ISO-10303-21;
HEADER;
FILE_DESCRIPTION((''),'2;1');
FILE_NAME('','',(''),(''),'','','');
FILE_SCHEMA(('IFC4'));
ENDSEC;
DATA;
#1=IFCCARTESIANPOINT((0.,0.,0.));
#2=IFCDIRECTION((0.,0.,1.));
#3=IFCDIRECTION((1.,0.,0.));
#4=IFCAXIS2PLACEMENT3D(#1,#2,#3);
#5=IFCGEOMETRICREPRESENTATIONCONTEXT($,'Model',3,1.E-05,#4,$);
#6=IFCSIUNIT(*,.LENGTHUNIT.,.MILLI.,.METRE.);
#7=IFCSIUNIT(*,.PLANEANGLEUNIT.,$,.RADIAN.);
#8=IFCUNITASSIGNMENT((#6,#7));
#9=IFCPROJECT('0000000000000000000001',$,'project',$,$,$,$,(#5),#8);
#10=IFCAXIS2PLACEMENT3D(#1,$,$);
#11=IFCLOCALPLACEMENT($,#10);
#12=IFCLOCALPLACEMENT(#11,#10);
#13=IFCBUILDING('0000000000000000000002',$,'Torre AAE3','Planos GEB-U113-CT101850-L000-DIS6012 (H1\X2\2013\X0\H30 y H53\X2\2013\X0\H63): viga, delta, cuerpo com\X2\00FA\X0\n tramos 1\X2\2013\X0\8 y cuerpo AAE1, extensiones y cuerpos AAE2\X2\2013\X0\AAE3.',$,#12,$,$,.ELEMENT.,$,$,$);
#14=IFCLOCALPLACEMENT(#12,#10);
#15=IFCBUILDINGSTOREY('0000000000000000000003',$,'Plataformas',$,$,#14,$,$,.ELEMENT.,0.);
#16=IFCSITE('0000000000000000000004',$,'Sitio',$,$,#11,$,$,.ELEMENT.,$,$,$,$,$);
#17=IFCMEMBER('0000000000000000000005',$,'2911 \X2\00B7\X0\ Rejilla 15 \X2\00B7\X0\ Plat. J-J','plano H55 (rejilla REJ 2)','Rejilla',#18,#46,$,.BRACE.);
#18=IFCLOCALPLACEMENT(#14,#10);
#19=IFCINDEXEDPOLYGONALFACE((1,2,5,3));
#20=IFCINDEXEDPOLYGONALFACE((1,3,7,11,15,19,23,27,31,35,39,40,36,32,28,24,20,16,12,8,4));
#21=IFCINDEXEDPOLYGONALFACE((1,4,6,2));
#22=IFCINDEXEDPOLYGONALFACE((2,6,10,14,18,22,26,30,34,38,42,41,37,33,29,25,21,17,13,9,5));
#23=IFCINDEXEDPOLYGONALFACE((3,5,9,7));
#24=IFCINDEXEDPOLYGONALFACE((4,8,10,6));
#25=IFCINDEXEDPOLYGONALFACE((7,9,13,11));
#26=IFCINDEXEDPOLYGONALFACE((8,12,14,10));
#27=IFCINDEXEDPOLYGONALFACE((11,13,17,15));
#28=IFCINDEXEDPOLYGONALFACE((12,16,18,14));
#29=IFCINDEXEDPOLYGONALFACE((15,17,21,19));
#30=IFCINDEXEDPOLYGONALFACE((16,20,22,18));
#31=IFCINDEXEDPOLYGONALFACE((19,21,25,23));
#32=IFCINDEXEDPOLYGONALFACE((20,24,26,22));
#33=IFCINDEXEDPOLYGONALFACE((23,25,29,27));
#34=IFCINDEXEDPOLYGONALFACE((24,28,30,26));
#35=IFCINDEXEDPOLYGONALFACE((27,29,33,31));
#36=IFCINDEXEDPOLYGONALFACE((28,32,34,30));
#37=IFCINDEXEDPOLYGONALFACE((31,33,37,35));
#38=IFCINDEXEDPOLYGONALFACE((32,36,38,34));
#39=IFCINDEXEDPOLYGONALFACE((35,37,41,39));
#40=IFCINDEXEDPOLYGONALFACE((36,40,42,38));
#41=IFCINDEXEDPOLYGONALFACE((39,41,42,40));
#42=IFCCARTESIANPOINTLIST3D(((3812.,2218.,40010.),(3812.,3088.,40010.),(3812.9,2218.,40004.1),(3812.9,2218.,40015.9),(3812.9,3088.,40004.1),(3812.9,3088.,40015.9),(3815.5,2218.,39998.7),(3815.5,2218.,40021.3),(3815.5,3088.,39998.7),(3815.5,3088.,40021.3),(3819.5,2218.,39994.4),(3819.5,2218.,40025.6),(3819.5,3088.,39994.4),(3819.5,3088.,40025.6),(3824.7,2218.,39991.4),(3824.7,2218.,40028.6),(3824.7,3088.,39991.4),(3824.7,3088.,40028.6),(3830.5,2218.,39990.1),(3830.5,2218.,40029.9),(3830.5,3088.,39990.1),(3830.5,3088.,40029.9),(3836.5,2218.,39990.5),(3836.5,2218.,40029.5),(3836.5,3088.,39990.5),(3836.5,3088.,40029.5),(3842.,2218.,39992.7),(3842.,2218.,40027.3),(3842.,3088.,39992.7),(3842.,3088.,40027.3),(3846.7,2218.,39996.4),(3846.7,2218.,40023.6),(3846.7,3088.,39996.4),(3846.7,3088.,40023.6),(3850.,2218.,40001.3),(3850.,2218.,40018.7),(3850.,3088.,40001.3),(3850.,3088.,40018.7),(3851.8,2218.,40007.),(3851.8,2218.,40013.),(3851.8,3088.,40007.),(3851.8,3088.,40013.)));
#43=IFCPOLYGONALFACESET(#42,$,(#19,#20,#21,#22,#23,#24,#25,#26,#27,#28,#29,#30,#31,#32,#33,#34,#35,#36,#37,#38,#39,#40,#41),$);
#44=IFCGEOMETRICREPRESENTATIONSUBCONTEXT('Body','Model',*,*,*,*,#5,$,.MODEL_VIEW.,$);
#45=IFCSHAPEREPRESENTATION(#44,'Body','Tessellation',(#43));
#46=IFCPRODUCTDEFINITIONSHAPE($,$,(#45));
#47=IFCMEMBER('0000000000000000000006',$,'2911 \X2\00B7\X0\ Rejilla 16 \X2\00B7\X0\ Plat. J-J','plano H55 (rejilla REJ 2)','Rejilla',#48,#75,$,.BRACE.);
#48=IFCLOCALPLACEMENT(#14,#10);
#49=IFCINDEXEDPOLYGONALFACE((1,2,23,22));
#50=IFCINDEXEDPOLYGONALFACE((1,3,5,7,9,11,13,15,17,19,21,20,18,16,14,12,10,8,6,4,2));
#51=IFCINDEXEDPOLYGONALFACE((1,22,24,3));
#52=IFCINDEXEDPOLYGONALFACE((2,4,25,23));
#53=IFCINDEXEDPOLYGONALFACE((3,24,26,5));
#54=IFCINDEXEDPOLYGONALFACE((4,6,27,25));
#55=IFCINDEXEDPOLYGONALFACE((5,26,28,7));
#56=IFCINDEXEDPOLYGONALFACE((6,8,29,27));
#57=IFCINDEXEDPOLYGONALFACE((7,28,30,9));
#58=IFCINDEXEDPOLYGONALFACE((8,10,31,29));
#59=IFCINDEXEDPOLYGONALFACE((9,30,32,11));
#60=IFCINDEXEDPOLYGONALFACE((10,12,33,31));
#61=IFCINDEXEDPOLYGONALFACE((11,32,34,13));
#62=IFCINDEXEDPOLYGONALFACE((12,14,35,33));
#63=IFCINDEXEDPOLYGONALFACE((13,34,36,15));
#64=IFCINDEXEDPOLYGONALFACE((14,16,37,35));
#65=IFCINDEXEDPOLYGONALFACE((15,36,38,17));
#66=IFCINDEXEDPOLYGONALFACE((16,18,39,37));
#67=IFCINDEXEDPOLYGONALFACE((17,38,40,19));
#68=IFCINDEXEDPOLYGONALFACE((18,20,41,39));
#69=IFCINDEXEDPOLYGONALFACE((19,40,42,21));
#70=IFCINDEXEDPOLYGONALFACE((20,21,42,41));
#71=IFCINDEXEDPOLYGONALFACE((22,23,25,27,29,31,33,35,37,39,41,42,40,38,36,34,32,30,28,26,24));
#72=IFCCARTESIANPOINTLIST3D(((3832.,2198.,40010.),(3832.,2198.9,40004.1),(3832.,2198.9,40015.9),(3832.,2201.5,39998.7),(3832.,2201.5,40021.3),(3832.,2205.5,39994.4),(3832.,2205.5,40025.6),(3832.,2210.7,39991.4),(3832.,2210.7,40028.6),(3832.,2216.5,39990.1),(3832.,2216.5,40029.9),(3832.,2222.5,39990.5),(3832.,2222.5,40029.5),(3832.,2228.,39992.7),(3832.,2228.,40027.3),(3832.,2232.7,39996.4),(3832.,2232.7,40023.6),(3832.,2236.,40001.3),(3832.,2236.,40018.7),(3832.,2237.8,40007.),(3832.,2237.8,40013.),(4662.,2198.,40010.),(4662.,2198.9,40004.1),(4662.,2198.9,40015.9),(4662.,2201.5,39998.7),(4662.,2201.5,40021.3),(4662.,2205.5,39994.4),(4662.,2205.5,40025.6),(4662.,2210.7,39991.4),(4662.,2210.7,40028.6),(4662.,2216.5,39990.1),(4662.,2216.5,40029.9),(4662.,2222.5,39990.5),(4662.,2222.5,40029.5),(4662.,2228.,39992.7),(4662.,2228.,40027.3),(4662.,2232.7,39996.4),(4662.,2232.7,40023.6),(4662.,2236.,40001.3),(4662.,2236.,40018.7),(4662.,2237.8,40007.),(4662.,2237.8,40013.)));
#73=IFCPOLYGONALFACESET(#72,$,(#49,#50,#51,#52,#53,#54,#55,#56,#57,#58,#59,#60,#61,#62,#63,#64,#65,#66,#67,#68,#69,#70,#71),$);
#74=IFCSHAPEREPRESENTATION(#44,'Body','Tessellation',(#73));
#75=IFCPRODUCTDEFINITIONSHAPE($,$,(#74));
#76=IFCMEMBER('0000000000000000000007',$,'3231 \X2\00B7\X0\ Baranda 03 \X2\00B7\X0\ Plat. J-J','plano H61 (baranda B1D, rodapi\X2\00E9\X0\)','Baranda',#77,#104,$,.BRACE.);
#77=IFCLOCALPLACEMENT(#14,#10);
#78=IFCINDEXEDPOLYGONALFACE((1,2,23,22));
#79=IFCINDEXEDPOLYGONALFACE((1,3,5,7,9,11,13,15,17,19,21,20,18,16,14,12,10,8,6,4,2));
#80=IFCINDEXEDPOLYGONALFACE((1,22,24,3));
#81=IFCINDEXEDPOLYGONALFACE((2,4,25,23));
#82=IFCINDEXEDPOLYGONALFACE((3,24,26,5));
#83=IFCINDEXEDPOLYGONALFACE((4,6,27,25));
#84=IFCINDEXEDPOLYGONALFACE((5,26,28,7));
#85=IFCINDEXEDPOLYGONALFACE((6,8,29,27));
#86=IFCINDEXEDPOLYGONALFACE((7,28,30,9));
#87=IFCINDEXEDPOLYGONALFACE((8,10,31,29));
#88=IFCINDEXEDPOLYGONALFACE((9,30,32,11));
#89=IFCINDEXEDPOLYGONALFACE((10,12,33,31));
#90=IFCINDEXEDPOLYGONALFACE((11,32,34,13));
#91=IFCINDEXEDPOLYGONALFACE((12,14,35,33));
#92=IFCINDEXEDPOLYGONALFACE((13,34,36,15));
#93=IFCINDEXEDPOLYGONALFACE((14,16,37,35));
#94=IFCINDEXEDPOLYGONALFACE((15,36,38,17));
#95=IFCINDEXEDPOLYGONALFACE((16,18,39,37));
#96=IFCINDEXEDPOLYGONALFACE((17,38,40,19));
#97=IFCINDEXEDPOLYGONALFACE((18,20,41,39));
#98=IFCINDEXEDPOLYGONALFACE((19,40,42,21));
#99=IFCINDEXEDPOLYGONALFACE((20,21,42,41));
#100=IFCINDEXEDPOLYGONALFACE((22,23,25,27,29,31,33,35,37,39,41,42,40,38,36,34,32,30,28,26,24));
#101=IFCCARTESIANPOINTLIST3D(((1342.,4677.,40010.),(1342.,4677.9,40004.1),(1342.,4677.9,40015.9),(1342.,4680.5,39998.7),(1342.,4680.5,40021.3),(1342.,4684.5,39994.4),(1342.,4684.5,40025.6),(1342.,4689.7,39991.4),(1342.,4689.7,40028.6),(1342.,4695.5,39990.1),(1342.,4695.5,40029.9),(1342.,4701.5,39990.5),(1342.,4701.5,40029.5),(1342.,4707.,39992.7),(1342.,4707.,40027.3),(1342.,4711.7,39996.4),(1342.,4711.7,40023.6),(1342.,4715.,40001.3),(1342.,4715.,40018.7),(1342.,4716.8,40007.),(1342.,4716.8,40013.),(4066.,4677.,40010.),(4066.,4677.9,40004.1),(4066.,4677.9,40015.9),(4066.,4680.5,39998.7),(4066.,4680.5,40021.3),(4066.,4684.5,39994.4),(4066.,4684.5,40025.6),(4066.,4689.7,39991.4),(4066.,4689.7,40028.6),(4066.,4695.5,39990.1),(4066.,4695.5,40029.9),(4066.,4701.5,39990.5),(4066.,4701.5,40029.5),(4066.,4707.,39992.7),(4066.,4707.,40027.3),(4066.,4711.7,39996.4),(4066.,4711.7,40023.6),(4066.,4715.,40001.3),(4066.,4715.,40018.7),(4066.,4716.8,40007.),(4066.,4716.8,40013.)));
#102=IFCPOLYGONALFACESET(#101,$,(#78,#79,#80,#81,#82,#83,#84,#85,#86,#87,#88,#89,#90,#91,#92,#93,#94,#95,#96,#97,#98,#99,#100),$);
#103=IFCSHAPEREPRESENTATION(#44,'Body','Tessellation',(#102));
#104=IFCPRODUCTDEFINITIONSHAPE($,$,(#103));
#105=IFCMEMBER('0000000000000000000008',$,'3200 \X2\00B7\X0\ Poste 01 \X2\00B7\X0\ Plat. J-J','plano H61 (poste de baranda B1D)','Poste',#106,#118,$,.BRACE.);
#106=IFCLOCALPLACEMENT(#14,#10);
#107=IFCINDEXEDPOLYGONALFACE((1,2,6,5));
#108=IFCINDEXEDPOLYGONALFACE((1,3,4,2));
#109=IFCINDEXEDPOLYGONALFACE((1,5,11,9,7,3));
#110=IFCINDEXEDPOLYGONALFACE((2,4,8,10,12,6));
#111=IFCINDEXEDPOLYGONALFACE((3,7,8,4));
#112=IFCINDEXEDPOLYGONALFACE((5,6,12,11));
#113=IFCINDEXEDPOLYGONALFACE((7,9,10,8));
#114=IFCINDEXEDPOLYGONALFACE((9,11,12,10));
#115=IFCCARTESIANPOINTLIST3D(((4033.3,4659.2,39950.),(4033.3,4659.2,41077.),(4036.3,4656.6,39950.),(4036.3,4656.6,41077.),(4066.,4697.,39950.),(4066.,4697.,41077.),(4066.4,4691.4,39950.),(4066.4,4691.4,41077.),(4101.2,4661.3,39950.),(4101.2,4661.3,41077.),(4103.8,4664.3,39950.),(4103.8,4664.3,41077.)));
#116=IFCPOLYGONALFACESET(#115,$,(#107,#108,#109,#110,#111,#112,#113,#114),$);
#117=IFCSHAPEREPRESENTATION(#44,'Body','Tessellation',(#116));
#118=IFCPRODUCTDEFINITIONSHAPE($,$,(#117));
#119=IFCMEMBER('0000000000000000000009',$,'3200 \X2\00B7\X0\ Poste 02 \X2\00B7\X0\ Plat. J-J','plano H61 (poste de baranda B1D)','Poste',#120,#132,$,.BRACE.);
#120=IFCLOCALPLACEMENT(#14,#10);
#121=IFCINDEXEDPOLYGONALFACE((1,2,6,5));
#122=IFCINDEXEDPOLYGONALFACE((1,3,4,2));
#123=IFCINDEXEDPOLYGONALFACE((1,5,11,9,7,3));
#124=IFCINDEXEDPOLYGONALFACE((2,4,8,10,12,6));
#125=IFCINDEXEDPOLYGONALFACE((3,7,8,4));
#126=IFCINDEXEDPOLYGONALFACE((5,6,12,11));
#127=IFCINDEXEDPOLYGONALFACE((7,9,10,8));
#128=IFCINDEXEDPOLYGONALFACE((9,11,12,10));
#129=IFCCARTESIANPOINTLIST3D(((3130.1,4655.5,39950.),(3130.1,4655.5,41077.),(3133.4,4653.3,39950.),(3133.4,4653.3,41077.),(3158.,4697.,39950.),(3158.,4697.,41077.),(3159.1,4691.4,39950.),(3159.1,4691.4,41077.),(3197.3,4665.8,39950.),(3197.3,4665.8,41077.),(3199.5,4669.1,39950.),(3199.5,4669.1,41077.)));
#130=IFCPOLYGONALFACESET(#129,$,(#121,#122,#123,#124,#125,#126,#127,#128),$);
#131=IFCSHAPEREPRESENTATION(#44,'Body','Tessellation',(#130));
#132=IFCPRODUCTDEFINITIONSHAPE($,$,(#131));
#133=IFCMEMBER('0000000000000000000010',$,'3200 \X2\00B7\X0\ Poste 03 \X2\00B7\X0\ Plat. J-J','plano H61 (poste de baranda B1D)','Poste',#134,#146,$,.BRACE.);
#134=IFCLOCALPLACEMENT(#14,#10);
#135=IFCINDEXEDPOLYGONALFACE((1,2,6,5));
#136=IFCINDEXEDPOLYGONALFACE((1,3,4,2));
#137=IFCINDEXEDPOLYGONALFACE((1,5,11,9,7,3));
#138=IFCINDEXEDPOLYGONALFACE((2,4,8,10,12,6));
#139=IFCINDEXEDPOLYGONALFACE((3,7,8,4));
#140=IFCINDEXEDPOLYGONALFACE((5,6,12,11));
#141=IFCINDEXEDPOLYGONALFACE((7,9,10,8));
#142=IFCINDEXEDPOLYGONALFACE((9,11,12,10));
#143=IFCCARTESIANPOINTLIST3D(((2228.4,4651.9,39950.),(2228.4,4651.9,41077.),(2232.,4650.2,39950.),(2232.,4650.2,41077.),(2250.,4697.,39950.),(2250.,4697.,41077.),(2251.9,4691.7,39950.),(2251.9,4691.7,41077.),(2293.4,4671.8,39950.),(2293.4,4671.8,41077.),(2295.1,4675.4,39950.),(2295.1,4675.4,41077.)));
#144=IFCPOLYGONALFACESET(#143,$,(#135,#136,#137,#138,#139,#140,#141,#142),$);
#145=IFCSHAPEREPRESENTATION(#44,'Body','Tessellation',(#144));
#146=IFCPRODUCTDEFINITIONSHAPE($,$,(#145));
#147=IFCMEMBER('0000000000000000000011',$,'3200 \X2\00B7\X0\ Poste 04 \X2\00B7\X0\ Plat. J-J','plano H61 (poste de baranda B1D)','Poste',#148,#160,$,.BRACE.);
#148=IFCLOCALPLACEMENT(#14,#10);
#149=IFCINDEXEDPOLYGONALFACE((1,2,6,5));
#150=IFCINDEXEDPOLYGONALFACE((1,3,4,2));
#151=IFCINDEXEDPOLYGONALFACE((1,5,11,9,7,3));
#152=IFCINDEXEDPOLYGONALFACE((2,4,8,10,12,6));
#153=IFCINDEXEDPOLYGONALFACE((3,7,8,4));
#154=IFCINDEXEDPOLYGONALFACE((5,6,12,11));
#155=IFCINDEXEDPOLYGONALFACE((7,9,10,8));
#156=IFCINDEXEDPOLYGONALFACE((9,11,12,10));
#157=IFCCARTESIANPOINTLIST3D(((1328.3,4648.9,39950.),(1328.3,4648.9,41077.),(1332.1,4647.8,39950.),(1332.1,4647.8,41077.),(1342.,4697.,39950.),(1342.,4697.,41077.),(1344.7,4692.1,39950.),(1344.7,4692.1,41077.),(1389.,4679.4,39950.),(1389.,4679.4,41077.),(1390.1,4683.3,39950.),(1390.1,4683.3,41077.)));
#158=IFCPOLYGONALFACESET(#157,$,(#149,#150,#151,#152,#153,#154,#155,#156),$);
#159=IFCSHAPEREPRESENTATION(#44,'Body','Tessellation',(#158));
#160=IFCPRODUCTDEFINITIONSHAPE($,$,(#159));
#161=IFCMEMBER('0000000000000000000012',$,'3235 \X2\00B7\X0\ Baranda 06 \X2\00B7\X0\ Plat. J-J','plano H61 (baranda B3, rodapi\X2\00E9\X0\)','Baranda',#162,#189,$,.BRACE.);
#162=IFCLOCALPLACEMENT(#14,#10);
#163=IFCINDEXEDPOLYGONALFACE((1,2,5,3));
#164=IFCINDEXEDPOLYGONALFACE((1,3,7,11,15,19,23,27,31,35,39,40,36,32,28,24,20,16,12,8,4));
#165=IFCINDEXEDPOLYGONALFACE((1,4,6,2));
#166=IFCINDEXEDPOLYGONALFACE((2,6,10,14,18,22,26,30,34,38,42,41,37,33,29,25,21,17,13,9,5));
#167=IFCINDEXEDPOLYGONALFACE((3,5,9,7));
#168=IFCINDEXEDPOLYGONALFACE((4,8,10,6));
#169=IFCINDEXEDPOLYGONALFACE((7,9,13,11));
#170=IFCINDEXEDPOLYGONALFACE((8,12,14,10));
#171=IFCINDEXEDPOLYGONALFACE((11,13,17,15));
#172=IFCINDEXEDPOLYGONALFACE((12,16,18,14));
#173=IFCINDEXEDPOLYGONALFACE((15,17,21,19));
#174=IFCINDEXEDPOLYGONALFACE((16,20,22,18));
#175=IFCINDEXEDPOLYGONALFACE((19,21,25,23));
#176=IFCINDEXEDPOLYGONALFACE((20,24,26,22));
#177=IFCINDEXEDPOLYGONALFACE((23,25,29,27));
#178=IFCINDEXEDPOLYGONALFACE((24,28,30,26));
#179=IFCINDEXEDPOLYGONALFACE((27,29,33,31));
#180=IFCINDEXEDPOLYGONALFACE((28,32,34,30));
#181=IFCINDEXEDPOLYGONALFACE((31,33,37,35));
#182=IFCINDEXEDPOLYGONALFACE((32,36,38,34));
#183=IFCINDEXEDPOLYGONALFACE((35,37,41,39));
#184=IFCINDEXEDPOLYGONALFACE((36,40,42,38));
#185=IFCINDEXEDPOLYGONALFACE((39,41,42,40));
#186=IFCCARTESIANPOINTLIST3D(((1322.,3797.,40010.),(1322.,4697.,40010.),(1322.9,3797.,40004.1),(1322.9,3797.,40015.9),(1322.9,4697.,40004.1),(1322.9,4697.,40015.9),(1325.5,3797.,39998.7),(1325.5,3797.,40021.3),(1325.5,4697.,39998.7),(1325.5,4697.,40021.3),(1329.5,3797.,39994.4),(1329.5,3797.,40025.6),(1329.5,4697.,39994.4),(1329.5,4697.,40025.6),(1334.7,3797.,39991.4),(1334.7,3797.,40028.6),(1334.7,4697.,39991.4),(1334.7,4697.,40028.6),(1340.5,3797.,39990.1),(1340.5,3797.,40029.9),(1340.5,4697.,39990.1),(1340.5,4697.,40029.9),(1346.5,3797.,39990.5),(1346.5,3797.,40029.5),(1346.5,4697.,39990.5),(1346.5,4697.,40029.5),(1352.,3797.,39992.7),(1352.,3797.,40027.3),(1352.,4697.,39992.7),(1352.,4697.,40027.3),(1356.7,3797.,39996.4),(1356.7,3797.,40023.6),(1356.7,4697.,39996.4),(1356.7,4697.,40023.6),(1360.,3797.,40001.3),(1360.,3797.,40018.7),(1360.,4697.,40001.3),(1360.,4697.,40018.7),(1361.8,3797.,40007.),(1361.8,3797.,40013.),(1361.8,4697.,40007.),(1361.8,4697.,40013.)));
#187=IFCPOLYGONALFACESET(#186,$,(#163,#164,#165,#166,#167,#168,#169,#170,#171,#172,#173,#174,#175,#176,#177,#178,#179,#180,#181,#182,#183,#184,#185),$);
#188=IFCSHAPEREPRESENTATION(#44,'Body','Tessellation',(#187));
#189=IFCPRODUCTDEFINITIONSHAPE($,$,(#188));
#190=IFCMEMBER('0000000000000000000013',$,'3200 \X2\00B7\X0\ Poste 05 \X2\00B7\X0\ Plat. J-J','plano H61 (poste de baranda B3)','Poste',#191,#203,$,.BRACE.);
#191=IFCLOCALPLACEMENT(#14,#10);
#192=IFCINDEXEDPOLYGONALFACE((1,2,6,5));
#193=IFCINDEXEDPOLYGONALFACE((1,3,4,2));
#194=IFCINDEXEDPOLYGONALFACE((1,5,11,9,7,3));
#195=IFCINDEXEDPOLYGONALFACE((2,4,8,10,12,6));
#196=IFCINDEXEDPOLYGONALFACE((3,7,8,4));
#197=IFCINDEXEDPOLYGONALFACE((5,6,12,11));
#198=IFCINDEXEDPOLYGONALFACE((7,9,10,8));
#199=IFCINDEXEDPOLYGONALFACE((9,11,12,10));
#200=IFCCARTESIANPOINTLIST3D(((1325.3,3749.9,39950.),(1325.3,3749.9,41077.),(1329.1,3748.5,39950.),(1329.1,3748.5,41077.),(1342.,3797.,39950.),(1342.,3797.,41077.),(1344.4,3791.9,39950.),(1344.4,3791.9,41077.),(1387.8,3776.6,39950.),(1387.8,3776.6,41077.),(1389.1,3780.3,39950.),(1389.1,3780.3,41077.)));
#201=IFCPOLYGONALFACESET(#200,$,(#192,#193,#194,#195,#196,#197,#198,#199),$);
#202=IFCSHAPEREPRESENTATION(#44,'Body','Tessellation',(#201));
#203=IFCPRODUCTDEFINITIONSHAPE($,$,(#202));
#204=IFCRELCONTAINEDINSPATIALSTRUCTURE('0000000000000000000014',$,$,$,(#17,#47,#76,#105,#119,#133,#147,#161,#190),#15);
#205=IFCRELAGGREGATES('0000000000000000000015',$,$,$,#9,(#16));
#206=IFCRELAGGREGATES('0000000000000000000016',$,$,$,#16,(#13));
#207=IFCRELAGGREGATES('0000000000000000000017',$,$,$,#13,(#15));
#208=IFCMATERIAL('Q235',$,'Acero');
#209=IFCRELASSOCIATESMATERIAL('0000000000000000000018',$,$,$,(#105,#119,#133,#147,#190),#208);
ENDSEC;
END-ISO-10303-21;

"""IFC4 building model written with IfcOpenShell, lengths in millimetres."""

from ifc_helpers import new_model, si_unit, frame, frame_2d, origin, origin_with_axes, place, context, subcontext, project, spatial, circle, l_section, extrude, material, element, save


model = new_model("IFC4")

# Units and contexts
model_context = context("Model", 3, precision=1e-05, world=origin_with_axes())
body_context = subcontext(model_context, "Body", "Model", "MODEL_VIEW")
ifc_project = project(units=[si_unit("LENGTHUNIT", "METRE", prefix="MILLI"), si_unit("PLANEANGLEUNIT", "RADIAN")], contexts=[model_context])

# Site, building, storey
site_placement = place(None, origin())
site = spatial("IfcSite", under=ifc_project, at=site_placement, Name="Sitio", CompositionType="ELEMENT")
building_placement = place(site_placement, origin())
building = spatial("IfcBuilding", under=site, at=building_placement, Name="Torre AAE3", Description="Planos GEB-U113-CT101850-L000-DIS6012 (H1–H30 y H53–H63): viga, delta, cuerpo común tramos 1–8 y cuerpo AAE1, extensiones y cuerpos AAE2–AAE3.", CompositionType="ELEMENT")
storey_placement = place(building_placement, origin())
storey = spatial("IfcBuildingStorey", under=building, at=storey_placement, Name="Plataformas", CompositionType="ELEMENT", Elevation=0.0)

# Members
member_1_placement = place(storey_placement, frame((3832.0, 3088.0, 40010.0), z_axis=(0.0, -1.0, 0.0), x_axis=(-1.0, 0.0, 0.0)))
element("IfcMember", 1, at=member_1_placement, inside=storey, Name="2911 · Rejilla 15 · Plat. J-J", Description="plano H55 (rejilla REJ 2)", ObjectType="Rejilla", PredefinedType="BRACE", context=body_context, shape_type="SweptSolid", body=[
    extrude(circle(Radius=20.0), None, (0.0, 0.0, 1.0), 870.0),
])
member_2_placement = place(storey_placement, frame((3832.0, 2218.0, 40010.0), z_axis=(1.0, 0.0, 0.0), x_axis=(0.0, -1.0, 0.0)))
element("IfcMember", 2, at=member_2_placement, inside=storey, Name="2911 · Rejilla 16 · Plat. J-J", Description="plano H55 (rejilla REJ 2)", ObjectType="Rejilla", PredefinedType="BRACE", context=body_context, shape_type="SweptSolid", body=[
    extrude(circle(Radius=20.0), None, (0.0, 0.0, 1.0), 830.0),
])
member_3_placement = place(storey_placement, frame((4066.0, 4697.0, 40010.0), z_axis=(-1.0, 0.0, 0.0), x_axis=(0.0, -1.0, 0.0)))
element("IfcMember", 3, at=member_3_placement, inside=storey, Name="3231 · Baranda 03 · Plat. J-J", Description="plano H61 (baranda B1D, rodapié)", ObjectType="Baranda", PredefinedType="BRACE", context=body_context, shape_type="SweptSolid", body=[
    extrude(circle(Radius=20.0), None, (0.0, 0.0, 1.0), 2724.0),
])
ifc_material = material(Name="Q235", Category="Acero")
for number, where, z_axis, x_axis, name in (
    (4, (4066.0, 4697.0, 39950.0), (0.0, 0.0, 1.0), (-0.654495, -0.756066, 0.0), "3200 · Poste 01 · Plat. J-J"),
    (5, (3158.0, 4697.0, 39950.0), (0.0, 0.0, 1.0), (-0.557958, -0.829869, 0.0), "3200 · Poste 02 · Plat. J-J"),
    (6, (2250.0, 4697.0, 39950.0), (0.0, 0.0, 1.0), (-0.432019, -0.901864, 0.0), "3200 · Poste 03 · Plat. J-J"),
    (7, (1342.0, 4697.0, 39950.0), (0.0, 0.0, 1.0), (-0.274721, -0.961524, 0.0), "3200 · Poste 04 · Plat. J-J"),
):
    element("IfcMember", number, at=place(storey_placement, frame(where, z_axis=z_axis, x_axis=x_axis)), inside=storey, material=ifc_material, Name=name, Description="plano H61 (poste de baranda B1D)", ObjectType="Poste", PredefinedType="BRACE", context=body_context, shape_type="SweptSolid", body=[
        extrude(l_section(Depth=50.0, Width=50.0, Thickness=4.0, at=frame_2d((25.0, 25.0))), None, (0.0, 0.0, 1.0), 1127.0),
    ])
member_4_placement = place(storey_placement, frame((1342.0, 4697.0, 40010.0), z_axis=(0.0, -1.0, 0.0), x_axis=(-1.0, 0.0, 0.0)))
element("IfcMember", 8, at=member_4_placement, inside=storey, Name="3235 · Baranda 06 · Plat. J-J", Description="plano H61 (baranda B3, rodapié)", ObjectType="Baranda", PredefinedType="BRACE", context=body_context, shape_type="SweptSolid", body=[
    extrude(circle(Radius=20.0), None, (0.0, 0.0, 1.0), 900.0),
])
member_5_placement = place(storey_placement, frame((1342.0, 3797.0, 39950.0), z_axis=(0.0, 0.0, 1.0), x_axis=(-0.333236, -0.942844, 0.0)))
element("IfcMember", 9, at=member_5_placement, inside=storey, material=ifc_material, Name="3200 · Poste 05 · Plat. J-J", Description="plano H61 (poste de baranda B3)", ObjectType="Poste", PredefinedType="BRACE", context=body_context, shape_type="SweptSolid", body=[
    extrude(l_section(Depth=50.0, Width=50.0, Thickness=4.0, at=frame_2d((25.0, 25.0))), None, (0.0, 0.0, 1.0), 1127.0),
])

save(model, "model.ifc")
